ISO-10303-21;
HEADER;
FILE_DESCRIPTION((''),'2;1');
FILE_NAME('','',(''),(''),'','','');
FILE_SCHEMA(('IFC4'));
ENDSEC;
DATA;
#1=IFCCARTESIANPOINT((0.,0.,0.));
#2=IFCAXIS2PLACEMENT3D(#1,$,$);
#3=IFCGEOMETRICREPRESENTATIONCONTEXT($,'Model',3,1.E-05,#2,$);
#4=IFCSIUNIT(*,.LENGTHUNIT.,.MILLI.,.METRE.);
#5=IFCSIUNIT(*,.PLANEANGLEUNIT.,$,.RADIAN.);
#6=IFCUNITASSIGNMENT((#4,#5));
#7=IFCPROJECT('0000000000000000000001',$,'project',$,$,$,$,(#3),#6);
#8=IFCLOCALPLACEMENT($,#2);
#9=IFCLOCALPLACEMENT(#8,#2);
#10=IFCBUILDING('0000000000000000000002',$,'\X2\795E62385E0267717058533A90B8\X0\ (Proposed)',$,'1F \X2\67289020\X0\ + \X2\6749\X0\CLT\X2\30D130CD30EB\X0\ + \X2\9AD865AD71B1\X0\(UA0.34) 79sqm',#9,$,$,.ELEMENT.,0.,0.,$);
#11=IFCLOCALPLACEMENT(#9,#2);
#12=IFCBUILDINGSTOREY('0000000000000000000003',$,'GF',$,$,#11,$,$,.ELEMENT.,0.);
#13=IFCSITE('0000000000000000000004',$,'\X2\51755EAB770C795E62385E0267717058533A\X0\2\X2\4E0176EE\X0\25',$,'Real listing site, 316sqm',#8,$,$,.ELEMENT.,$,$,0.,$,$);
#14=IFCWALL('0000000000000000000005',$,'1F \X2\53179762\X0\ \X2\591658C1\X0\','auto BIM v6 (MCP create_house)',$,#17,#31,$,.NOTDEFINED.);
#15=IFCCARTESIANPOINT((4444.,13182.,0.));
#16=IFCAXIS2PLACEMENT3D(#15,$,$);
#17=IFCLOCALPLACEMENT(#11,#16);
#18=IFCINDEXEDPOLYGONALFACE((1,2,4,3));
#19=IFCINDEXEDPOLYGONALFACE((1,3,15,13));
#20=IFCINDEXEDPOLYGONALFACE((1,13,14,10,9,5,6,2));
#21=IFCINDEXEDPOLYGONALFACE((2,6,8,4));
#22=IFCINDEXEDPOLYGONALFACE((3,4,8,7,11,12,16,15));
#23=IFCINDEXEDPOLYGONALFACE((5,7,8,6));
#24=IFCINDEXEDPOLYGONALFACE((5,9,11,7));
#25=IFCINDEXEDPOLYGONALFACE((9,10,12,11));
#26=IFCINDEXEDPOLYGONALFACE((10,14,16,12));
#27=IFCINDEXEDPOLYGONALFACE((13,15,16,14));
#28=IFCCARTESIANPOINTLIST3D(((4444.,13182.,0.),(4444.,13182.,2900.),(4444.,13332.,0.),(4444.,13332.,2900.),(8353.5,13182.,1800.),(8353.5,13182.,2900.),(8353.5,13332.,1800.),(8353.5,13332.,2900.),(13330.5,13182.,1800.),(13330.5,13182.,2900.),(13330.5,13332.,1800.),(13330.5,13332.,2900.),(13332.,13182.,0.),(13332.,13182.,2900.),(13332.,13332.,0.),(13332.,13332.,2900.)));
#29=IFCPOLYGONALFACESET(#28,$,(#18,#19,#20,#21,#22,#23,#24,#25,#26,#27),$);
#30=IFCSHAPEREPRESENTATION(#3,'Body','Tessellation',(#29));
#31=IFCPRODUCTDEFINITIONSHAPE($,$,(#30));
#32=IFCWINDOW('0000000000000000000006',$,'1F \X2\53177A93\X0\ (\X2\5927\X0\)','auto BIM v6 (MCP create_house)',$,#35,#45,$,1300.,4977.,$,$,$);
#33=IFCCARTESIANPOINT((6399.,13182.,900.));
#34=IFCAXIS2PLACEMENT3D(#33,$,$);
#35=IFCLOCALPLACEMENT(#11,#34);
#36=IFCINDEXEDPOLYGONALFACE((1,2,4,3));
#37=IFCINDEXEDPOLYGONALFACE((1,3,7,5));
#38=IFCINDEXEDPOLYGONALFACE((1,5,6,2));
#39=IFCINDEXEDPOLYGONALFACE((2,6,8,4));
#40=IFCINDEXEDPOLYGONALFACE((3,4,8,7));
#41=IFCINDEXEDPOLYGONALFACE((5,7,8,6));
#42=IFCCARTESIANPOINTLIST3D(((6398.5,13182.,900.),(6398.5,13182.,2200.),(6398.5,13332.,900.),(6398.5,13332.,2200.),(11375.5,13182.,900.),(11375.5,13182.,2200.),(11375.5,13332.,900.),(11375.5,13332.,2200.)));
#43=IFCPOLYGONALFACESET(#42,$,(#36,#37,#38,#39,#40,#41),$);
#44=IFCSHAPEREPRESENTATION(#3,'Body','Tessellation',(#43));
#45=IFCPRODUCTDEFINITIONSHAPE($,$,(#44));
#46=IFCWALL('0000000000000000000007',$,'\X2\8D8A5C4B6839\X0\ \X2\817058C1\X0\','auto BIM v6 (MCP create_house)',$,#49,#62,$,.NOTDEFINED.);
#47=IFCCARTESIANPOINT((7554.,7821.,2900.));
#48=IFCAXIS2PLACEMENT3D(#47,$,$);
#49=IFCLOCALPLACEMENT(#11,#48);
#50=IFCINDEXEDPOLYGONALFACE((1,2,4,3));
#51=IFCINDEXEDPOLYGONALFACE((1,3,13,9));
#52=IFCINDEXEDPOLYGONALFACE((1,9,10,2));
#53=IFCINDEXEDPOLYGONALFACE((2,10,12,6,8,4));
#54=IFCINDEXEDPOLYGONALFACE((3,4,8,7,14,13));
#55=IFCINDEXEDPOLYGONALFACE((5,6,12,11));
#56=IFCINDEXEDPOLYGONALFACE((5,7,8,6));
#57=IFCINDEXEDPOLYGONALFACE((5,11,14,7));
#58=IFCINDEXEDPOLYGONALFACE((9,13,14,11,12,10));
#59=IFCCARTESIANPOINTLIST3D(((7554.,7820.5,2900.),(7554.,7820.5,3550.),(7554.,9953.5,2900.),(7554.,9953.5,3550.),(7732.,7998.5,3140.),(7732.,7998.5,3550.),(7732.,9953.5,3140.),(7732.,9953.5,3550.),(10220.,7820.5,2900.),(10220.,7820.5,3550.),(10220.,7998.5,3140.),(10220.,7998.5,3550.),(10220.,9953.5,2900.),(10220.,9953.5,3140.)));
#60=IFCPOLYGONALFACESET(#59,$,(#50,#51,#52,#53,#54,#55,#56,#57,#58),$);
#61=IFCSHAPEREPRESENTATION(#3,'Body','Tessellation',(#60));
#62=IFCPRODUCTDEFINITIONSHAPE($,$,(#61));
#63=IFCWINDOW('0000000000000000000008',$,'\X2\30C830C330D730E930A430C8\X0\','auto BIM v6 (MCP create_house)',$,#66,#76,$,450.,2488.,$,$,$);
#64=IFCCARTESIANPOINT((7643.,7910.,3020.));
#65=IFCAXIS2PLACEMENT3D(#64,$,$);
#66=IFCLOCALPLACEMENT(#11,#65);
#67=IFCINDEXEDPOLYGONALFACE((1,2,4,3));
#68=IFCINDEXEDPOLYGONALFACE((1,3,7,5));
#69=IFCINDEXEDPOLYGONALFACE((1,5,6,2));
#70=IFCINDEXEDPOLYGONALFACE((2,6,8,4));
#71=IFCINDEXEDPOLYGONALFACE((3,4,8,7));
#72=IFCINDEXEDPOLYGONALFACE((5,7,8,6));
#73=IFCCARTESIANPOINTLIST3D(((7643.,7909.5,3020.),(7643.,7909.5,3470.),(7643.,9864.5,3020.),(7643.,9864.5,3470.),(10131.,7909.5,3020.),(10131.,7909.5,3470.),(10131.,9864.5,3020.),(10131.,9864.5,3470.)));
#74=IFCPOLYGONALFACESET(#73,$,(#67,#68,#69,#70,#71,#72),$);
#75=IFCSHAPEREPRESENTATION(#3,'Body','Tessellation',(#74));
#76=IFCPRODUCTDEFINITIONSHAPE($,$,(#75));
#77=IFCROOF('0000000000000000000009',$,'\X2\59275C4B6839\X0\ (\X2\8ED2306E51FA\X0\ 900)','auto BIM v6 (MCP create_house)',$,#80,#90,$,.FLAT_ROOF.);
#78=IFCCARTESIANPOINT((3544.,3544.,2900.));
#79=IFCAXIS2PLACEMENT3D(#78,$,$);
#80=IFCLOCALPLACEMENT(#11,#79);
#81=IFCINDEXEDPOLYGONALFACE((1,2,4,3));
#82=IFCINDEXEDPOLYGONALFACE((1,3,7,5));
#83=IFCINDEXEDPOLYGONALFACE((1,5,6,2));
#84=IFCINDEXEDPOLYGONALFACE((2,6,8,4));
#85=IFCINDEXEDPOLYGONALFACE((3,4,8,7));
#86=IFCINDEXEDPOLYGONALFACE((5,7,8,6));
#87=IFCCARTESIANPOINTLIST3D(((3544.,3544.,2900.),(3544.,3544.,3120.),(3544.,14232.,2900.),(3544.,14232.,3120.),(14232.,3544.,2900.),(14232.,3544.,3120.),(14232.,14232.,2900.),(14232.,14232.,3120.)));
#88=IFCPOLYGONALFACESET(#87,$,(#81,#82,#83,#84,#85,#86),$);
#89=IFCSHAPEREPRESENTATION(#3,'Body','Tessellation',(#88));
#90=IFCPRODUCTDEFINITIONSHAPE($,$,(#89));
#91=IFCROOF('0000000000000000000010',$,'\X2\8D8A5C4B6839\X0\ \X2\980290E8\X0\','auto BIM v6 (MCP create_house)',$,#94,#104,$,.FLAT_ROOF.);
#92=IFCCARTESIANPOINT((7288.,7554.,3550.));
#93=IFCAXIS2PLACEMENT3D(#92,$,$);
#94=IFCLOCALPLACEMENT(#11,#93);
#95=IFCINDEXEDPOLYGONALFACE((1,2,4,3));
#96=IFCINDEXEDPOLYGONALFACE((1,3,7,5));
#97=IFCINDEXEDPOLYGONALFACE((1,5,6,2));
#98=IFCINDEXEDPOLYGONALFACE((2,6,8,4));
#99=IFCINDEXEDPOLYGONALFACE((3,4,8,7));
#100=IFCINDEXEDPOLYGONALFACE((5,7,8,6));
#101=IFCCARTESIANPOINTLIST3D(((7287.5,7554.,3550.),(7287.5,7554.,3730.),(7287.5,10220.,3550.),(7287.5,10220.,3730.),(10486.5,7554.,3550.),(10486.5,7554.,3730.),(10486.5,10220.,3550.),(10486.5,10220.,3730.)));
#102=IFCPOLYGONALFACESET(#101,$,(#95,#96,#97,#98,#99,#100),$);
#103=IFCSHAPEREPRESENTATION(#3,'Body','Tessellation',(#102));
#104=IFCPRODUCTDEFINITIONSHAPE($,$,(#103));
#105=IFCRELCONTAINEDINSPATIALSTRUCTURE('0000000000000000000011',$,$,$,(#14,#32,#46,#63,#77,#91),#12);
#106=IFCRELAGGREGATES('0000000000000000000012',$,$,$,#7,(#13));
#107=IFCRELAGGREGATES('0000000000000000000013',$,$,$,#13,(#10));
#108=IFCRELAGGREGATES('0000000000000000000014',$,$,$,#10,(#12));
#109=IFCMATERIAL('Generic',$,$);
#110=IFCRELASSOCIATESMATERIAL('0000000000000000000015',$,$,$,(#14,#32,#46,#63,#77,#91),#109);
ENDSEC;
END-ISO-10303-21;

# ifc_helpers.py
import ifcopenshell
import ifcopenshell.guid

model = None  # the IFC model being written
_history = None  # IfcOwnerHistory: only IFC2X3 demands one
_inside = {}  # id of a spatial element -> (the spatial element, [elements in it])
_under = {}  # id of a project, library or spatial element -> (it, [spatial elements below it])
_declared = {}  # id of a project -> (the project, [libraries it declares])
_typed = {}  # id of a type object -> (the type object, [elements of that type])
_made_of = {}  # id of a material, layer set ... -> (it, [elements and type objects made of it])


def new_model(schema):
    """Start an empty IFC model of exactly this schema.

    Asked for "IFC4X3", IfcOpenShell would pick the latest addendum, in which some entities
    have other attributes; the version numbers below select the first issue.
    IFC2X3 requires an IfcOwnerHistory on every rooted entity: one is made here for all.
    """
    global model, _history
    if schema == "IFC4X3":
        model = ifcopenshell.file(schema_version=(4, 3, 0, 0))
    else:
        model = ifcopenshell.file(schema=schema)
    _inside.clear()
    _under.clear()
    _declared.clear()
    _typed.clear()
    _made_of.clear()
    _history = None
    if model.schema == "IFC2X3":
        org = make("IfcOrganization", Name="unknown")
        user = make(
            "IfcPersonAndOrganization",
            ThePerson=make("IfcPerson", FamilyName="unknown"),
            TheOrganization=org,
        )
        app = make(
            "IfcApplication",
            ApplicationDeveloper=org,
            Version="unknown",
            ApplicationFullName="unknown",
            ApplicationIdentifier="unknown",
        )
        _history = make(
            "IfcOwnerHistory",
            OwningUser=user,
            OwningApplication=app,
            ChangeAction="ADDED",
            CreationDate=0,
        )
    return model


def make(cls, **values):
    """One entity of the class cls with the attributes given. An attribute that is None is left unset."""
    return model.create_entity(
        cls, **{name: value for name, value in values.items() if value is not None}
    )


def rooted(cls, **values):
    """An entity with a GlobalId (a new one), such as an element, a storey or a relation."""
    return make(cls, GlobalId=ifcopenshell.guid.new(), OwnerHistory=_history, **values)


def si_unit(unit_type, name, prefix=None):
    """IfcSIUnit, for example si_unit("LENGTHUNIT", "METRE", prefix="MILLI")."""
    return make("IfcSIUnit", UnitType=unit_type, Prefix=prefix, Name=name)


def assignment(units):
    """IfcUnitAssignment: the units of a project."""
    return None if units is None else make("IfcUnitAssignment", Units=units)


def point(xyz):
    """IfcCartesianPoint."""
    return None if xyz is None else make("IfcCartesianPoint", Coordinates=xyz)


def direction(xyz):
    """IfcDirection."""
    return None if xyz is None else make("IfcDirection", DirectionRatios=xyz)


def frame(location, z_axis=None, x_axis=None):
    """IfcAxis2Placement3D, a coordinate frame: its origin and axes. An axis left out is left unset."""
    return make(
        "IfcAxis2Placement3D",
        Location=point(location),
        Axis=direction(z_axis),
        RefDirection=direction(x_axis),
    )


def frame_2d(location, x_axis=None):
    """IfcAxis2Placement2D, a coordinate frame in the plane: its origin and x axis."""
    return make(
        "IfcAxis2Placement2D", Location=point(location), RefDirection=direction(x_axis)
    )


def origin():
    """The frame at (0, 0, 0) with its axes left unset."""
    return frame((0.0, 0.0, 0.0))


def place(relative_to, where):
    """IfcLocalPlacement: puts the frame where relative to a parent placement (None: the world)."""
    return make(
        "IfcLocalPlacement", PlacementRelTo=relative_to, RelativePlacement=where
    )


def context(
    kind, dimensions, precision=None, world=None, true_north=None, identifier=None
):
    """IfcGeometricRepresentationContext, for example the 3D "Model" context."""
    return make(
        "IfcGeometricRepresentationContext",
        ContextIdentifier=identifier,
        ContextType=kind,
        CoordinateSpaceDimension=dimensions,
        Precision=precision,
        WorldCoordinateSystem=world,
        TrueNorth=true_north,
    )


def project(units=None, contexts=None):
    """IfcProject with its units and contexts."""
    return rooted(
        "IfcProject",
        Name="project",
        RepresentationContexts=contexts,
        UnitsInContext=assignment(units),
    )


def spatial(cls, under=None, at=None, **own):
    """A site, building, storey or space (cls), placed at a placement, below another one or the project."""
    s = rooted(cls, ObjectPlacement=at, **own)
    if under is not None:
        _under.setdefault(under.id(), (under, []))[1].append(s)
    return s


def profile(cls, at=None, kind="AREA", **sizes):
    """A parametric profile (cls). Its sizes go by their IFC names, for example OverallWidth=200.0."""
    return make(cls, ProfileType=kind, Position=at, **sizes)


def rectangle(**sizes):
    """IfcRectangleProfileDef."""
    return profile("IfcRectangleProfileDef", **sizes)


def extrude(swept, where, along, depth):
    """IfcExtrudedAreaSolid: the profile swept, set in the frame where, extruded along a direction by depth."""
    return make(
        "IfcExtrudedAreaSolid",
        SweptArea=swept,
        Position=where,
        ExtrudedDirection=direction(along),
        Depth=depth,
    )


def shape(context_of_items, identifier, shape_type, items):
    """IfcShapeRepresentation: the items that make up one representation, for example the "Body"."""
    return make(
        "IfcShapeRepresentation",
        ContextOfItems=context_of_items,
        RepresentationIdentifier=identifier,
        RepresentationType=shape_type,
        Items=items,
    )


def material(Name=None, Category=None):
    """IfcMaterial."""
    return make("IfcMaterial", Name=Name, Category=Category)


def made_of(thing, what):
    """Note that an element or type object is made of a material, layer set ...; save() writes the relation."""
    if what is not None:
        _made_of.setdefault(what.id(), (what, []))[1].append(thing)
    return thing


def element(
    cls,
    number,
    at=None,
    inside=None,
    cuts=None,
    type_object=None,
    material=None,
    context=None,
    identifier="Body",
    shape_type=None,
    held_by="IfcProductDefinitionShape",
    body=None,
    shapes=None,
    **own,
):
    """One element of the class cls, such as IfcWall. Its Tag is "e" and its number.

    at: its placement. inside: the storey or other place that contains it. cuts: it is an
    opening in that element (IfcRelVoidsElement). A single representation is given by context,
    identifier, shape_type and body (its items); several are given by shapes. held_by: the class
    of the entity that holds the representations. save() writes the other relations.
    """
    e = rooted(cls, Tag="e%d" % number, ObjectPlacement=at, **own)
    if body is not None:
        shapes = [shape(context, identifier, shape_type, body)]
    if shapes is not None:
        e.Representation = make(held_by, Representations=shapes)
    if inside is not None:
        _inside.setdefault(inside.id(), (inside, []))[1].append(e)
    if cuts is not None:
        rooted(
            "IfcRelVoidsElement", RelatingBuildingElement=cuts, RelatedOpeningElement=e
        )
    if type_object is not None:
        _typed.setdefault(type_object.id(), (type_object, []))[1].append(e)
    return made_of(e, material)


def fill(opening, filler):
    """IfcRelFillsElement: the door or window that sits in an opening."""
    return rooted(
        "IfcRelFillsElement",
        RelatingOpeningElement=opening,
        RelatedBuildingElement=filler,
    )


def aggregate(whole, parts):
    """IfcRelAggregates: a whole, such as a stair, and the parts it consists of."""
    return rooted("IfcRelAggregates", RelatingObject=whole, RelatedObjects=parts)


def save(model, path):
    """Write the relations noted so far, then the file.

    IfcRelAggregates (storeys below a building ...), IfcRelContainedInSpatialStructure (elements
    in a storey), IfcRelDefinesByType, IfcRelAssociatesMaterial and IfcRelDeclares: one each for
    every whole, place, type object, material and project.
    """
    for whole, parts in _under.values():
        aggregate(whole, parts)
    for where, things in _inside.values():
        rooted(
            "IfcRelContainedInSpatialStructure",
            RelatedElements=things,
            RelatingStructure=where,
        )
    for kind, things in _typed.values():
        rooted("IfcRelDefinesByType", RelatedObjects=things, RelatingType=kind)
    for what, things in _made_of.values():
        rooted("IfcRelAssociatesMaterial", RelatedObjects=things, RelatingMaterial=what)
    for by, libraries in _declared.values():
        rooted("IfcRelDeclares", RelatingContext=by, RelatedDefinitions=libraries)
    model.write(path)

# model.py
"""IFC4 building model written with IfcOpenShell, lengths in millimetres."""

from ifc_helpers import new_model, si_unit, frame, frame_2d, origin, place, context, project, spatial, rectangle, extrude, material, element, fill, save


model = new_model("IFC4")

# Units and contexts
model_context = context("Model", 3, precision=1e-05, world=origin())
ifc_project = project(units=[si_unit("LENGTHUNIT", "METRE", prefix="MILLI"), si_unit("PLANEANGLEUNIT", "RADIAN")], contexts=[model_context])

# Site, building, storey
site_placement = place(None, origin())
site = spatial("IfcSite", under=ifc_project, at=site_placement, Name="兵庫県神戸市東灘区2丁目25", ObjectType="Real listing site, 316sqm", CompositionType="ELEMENT", RefElevation=0.0)
building_placement = place(site_placement, origin())
building = spatial("IfcBuilding", under=site, at=building_placement, Name="神戸市東灘区邸 (Proposed)", ObjectType="1F 木造 + 杉CLTパネル + 高断熱(UA0.34) 79sqm", CompositionType="ELEMENT", ElevationOfRefHeight=0.0, ElevationOfTerrain=0.0)
storey_placement = place(building_placement, origin())
storey = spatial("IfcBuildingStorey", under=building, at=storey_placement, Name="GF", CompositionType="ELEMENT", Elevation=0.0)

# Shared definitions
ifc_material = material(Name="Generic")

# Wall, opening, window
wall_1_placement = place(storey_placement, frame((4444.0, 13182.0, 0.0)))
wall_1 = element("IfcWall", 1, at=wall_1_placement, inside=storey, material=ifc_material, Name="1F 北面 外壁", Description="auto BIM v6 (MCP create_house)", PredefinedType="NOTDEFINED", context=model_context, shape_type="SweptSolid", body=[
    extrude(rectangle(XDim=8888.0, YDim=150.0, at=frame_2d((4444.0, 75.0))), frame((4444.0, 13182.0, 0.0)), (0.0, 0.0, 1.0), 2900.0),
])
opening_1_placement = place(storey_placement, frame((6399.0, 13182.0, 900.0)))
opening_1 = element("IfcOpeningElement", 2, at=opening_1_placement, cuts=wall_1, PredefinedType="NOTDEFINED", context=model_context, shape_type="SweptSolid", body=[
    extrude(rectangle(XDim=4977.0, YDim=150.0, at=frame_2d((2488.0, 75.0))), frame((6399.0, 13182.0, 900.0)), (0.0, 0.0, 1.0), 1300.0),
])
window_1_placement = place(storey_placement, frame((6399.0, 13182.0, 900.0)))
window_1 = element("IfcWindow", 3, at=window_1_placement, inside=storey, material=ifc_material, Name="1F 北窓 (大)", Description="auto BIM v6 (MCP create_house)", OverallHeight=1300.0, OverallWidth=4977.0, context=model_context, shape_type="SweptSolid", body=[
    extrude(rectangle(XDim=4977.0, YDim=150.0, at=frame_2d((2488.0, 75.0))), frame((6399.0, 13182.0, 900.0)), (0.0, 0.0, 1.0), 1300.0),
])
fill(opening_1, window_1)

# Wall, opening, window
wall_2_placement = place(storey_placement, frame((7554.0, 7821.0, 2900.0)))
wall_2 = element("IfcWall", 4, at=wall_2_placement, inside=storey, material=ifc_material, Name="越屋根 腰壁", Description="auto BIM v6 (MCP create_house)", PredefinedType="NOTDEFINED", context=model_context, shape_type="SweptSolid", body=[
    extrude(rectangle(XDim=2666.0, YDim=2133.0, at=frame_2d((1333.0, 1066.0))), frame((7554.0, 7821.0, 2900.0)), (0.0, 0.0, 1.0), 650.0),
])
opening_2_placement = place(storey_placement, frame((7643.0, 7910.0, 3020.0)))
opening_2 = element("IfcOpeningElement", 5, at=opening_2_placement, cuts=wall_2, PredefinedType="NOTDEFINED", context=model_context, shape_type="SweptSolid", body=[
    extrude(rectangle(XDim=2488.0, YDim=1955.0, at=frame_2d((1244.0, 977.0))), frame((7643.0, 7910.0, 3020.0)), (0.0, 0.0, 1.0), 450.0),
])
window_2_placement = place(storey_placement, frame((7643.0, 7910.0, 3020.0)))
window_2 = element("IfcWindow", 6, at=window_2_placement, inside=storey, material=ifc_material, Name="トップライト", Description="auto BIM v6 (MCP create_house)", OverallHeight=450.0, OverallWidth=2488.0, context=model_context, shape_type="SweptSolid", body=[
    extrude(rectangle(XDim=2488.0, YDim=1955.0, at=frame_2d((1244.0, 977.0))), frame((7643.0, 7910.0, 3020.0)), (0.0, 0.0, 1.0), 450.0),
])
fill(opening_2, window_2)

# Roofs
roof_1_placement = place(storey_placement, frame((3544.0, 3544.0, 2900.0)))
element("IfcRoof", 7, at=roof_1_placement, inside=storey, material=ifc_material, Name="大屋根 (軒の出 900)", Description="auto BIM v6 (MCP create_house)", PredefinedType="FLAT_ROOF", context=model_context, shape_type="SweptSolid", body=[
    extrude(rectangle(XDim=10688.0, YDim=10688.0, at=frame_2d((5344.0, 5344.0))), frame((3544.0, 3544.0, 2900.0)), (0.0, 0.0, 1.0), 220.0),
])
roof_2_placement = place(storey_placement, frame((7288.0, 7554.0, 3550.0)))
element("IfcRoof", 8, at=roof_2_placement, inside=storey, material=ifc_material, Name="越屋根 頂部", Description="auto BIM v6 (MCP create_house)", PredefinedType="FLAT_ROOF", context=model_context, shape_type="SweptSolid", body=[
    extrude(rectangle(XDim=3199.0, YDim=2666.0, at=frame_2d((1599.0, 1333.0))), frame((7288.0, 7554.0, 3550.0)), (0.0, 0.0, 1.0), 180.0),
])

save(model, "model.ifc")
